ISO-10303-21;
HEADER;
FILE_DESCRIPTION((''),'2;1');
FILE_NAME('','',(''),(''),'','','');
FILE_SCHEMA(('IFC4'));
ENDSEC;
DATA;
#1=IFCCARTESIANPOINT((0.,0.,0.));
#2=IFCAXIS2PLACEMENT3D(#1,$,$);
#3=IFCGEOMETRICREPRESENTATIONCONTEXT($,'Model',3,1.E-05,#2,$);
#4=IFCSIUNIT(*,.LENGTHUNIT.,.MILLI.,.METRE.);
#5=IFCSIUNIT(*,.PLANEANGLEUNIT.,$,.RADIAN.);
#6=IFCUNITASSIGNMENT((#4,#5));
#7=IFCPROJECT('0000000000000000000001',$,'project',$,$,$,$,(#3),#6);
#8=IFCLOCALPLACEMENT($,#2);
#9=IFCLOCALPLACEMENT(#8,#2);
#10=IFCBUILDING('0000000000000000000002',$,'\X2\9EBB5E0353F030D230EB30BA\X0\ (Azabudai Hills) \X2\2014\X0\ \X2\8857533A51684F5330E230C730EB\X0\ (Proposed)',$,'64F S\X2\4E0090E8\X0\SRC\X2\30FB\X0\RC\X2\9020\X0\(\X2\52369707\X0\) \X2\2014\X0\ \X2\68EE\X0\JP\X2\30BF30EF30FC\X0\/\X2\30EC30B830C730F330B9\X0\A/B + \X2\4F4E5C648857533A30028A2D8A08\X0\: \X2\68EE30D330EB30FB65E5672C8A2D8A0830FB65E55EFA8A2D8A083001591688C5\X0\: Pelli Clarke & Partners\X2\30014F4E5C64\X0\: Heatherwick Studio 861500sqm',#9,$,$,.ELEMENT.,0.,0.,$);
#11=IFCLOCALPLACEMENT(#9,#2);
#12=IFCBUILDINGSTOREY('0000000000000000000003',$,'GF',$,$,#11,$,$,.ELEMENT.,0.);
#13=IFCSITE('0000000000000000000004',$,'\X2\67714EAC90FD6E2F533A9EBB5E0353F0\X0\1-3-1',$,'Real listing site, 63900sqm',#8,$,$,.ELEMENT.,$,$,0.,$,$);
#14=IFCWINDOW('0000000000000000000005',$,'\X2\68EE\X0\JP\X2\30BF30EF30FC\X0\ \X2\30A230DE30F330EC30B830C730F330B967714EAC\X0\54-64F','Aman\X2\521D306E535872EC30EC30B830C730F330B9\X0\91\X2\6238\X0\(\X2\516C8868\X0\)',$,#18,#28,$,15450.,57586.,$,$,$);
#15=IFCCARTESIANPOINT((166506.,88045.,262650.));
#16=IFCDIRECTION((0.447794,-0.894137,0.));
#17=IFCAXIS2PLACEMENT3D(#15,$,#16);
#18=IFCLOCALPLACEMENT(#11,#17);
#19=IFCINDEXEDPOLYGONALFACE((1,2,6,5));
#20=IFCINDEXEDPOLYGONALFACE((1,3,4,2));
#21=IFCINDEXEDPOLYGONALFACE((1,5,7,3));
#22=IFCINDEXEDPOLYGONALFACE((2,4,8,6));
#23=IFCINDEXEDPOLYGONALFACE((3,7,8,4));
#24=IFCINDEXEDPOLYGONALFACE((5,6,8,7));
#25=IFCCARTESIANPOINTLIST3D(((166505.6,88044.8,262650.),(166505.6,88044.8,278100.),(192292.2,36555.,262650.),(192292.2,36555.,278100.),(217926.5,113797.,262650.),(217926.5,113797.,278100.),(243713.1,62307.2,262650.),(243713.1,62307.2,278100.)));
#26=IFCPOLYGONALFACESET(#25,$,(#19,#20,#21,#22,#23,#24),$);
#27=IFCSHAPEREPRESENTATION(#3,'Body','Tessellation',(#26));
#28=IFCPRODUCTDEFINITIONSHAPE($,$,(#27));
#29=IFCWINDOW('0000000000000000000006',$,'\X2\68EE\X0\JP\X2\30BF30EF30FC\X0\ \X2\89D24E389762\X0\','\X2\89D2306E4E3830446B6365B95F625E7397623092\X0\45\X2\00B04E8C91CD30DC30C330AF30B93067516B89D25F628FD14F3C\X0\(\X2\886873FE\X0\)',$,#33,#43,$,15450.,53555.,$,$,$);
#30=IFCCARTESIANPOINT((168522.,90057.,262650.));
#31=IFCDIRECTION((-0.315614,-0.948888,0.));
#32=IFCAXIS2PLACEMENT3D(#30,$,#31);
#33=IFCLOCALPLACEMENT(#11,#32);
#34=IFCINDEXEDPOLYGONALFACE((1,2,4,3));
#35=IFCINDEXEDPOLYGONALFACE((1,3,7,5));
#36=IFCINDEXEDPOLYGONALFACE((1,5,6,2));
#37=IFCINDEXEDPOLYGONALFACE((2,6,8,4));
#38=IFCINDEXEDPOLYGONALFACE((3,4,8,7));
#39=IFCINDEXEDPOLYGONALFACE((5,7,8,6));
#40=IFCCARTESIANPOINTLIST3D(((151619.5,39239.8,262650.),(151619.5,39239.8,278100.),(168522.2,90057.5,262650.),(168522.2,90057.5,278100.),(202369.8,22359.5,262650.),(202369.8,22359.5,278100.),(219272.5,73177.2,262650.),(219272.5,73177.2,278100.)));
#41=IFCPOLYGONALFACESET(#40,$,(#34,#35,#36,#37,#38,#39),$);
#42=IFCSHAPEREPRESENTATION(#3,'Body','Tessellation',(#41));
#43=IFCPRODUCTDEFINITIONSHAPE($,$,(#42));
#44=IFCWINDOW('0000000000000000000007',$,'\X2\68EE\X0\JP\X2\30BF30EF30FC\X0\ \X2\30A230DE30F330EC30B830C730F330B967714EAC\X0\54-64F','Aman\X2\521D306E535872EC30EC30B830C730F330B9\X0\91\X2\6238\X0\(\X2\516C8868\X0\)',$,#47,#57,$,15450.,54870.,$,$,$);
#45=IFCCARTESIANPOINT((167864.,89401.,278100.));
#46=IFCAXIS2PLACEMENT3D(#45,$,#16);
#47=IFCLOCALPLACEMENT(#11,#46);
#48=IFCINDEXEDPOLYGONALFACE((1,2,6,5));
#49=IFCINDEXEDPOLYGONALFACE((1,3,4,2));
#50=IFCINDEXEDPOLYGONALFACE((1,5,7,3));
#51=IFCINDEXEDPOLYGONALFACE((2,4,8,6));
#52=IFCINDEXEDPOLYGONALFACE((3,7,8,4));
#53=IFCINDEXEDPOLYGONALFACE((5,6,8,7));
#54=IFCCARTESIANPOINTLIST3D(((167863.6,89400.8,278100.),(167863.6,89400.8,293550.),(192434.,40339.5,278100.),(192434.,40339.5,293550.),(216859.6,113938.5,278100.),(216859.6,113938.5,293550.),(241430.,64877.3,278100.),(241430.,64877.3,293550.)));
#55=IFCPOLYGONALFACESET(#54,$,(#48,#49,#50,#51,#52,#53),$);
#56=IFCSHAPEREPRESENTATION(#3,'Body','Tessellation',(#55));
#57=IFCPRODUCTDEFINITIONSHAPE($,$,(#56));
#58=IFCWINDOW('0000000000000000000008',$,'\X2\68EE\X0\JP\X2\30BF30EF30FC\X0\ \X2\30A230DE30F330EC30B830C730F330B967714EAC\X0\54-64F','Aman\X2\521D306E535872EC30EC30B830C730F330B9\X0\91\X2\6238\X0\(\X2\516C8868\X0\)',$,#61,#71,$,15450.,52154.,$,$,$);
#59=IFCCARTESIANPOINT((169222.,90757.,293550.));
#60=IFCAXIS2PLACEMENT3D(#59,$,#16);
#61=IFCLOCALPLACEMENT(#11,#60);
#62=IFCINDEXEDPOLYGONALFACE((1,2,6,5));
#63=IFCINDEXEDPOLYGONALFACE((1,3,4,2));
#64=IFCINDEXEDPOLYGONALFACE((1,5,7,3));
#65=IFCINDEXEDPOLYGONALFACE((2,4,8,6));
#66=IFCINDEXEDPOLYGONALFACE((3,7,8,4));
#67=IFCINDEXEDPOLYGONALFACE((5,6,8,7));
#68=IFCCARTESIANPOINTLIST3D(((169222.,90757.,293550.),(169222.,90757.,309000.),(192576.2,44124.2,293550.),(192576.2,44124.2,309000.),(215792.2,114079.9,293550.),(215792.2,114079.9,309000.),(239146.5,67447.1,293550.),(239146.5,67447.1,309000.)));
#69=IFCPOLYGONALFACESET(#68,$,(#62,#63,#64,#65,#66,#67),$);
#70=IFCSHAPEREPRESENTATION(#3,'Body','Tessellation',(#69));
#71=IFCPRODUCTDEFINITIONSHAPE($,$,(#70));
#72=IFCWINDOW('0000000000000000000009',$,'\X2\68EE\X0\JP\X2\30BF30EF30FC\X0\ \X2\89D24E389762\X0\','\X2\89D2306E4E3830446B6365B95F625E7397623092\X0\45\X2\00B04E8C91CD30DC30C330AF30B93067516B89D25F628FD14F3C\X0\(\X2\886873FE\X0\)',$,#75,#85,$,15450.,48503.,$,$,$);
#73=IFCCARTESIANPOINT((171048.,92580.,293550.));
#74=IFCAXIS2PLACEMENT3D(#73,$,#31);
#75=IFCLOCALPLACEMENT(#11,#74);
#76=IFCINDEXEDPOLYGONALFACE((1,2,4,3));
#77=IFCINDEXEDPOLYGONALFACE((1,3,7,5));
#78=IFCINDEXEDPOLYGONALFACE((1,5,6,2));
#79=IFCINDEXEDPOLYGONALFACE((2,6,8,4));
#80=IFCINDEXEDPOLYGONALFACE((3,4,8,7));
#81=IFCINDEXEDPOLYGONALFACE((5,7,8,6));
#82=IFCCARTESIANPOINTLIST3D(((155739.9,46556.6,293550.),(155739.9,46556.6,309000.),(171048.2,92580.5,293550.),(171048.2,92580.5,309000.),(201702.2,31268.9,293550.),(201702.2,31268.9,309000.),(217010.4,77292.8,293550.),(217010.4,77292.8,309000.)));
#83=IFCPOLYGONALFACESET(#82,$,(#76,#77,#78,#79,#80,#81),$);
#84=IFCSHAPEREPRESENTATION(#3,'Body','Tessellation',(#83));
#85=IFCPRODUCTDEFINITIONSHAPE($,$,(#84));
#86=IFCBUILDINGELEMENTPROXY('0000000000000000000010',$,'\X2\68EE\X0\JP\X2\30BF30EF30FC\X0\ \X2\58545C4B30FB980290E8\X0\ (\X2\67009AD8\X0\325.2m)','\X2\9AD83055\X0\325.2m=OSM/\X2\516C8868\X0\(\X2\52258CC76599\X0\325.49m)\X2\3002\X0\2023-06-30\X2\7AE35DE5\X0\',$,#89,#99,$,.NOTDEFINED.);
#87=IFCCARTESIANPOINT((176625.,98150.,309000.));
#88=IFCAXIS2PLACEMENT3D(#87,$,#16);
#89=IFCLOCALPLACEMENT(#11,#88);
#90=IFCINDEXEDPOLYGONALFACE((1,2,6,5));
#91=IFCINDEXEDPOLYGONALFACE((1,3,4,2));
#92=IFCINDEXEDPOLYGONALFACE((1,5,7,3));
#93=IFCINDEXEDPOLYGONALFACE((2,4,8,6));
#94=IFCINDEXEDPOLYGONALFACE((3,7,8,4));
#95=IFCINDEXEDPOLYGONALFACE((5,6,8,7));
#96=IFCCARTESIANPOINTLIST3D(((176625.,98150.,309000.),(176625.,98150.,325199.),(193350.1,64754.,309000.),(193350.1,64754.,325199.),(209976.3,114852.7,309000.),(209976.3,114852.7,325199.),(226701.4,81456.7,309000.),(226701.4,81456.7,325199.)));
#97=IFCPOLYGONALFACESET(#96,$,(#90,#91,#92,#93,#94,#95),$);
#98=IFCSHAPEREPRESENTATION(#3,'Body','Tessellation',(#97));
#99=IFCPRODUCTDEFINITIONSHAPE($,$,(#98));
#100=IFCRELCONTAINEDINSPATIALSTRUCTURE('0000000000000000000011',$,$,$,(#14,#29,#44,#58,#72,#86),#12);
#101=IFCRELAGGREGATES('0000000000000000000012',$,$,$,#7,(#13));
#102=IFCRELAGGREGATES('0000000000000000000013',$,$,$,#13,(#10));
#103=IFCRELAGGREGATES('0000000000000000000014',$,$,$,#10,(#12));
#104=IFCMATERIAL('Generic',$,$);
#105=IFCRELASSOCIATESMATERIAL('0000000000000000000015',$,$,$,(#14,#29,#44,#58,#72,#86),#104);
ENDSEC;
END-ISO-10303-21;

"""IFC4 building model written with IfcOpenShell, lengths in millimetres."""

from ifc_helpers import new_model, si_unit, frame, frame_2d, origin, place, context, project, spatial, rectangle, extrude, material, element, save


model = new_model("IFC4")

# Units and contexts
model_context = context("Model", 3, precision=1e-05, world=origin())
ifc_project = project(units=[si_unit("LENGTHUNIT", "METRE", prefix="MILLI"), si_unit("PLANEANGLEUNIT", "RADIAN")], contexts=[model_context])

# Site, building, storey
site_placement = place(None, origin())
site = spatial("IfcSite", under=ifc_project, at=site_placement, Name="東京都港区麻布台1-3-1", ObjectType="Real listing site, 63900sqm", CompositionType="ELEMENT", RefElevation=0.0)
building_placement = place(site_placement, origin())
building = spatial("IfcBuilding", under=site, at=building_placement, Name="麻布台ヒルズ (Azabudai Hills) — 街区全体モデル (Proposed)", ObjectType="64F S一部SRC・RC造(制震) — 森JPタワー/レジデンスA/B + 低層街区。設計: 森ビル・日本設計・日建設計、外装: Pelli Clarke & Partners、低層: Heatherwick Studio 861500sqm", CompositionType="ELEMENT", ElevationOfRefHeight=0.0, ElevationOfTerrain=0.0)
storey_placement = place(building_placement, origin())
storey = spatial("IfcBuildingStorey", under=building, at=storey_placement, Name="GF", CompositionType="ELEMENT", Elevation=0.0)

# Windows
ifc_material = material(Name="Generic")
window_1_placement = place(storey_placement, frame((166506.0, 88045.0, 262650.0), x_axis=(0.447794, -0.894137, 0.0)))
element("IfcWindow", 1, at=window_1_placement, inside=storey, material=ifc_material, Name="森JPタワー アマンレジデンス東京54-64F", Description="Aman初の単独レジデンス91戸(公表)", OverallHeight=15450.0, OverallWidth=57586.0, context=model_context, shape_type="SweptSolid", body=[
    extrude(rectangle(XDim=57586.0, YDim=57509.0, at=frame_2d((28793.0, 28754.0))), frame((166506.0, 88045.0, 262650.0), x_axis=(0.447794, -0.894137, 0.0)), (0.0, 0.0, 1.0), 15450.0),
])
window_2_placement = place(storey_placement, frame((168522.0, 90057.0, 262650.0), x_axis=(-0.315614, -0.948888, 0.0)))
element("IfcWindow", 2, at=window_2_placement, inside=storey, material=ifc_material, Name="森JPタワー 角丸面", Description="角の丸い正方形平面を45°二重ボックスで八角形近似(表現)", OverallHeight=15450.0, OverallWidth=53555.0, context=model_context, shape_type="SweptSolid", body=[
    extrude(rectangle(XDim=53555.0, YDim=53484.0, at=frame_2d((26777.0, 26742.0))), frame((168522.0, 90057.0, 262650.0), x_axis=(-0.315614, -0.948888, 0.0)), (0.0, 0.0, 1.0), 15450.0),
])
window_3_placement = place(storey_placement, frame((167864.0, 89401.0, 278100.0), x_axis=(0.447794, -0.894137, 0.0)))
element("IfcWindow", 3, at=window_3_placement, inside=storey, material=ifc_material, Name="森JPタワー アマンレジデンス東京54-64F", Description="Aman初の単独レジデンス91戸(公表)", OverallHeight=15450.0, OverallWidth=54870.0, context=model_context, shape_type="SweptSolid", body=[
    extrude(rectangle(XDim=54870.0, YDim=54797.0, at=frame_2d((27435.0, 27398.0))), frame((167864.0, 89401.0, 278100.0), x_axis=(0.447794, -0.894137, 0.0)), (0.0, 0.0, 1.0), 15450.0),
])
window_4_placement = place(storey_placement, frame((169222.0, 90757.0, 293550.0), x_axis=(0.447794, -0.894137, 0.0)))
element("IfcWindow", 4, at=window_4_placement, inside=storey, material=ifc_material, Name="森JPタワー アマンレジデンス東京54-64F", Description="Aman初の単独レジデンス91戸(公表)", OverallHeight=15450.0, OverallWidth=52154.0, context=model_context, shape_type="SweptSolid", body=[
    extrude(rectangle(XDim=52154.0, YDim=52084.0, at=frame_2d((26077.0, 26042.0))), frame((169222.0, 90757.0, 293550.0), x_axis=(0.447794, -0.894137, 0.0)), (0.0, 0.0, 1.0), 15450.0),
])
window_5_placement = place(storey_placement, frame((171048.0, 92580.0, 293550.0), x_axis=(-0.315614, -0.948888, 0.0)))
element("IfcWindow", 5, at=window_5_placement, inside=storey, material=ifc_material, Name="森JPタワー 角丸面", Description="角の丸い正方形平面を45°二重ボックスで八角形近似(表現)", OverallHeight=15450.0, OverallWidth=48503.0, context=model_context, shape_type="SweptSolid", body=[
    extrude(rectangle(XDim=48503.0, YDim=48438.0, at=frame_2d((24251.0, 24219.0))), frame((171048.0, 92580.0, 293550.0), x_axis=(-0.315614, -0.948888, 0.0)), (0.0, 0.0, 1.0), 15450.0),
])

# Building element proxy
proxy_placement = place(storey_placement, frame((176625.0, 98150.0, 309000.0), x_axis=(0.447794, -0.894137, 0.0)))
element("IfcBuildingElementProxy", 6, at=proxy_placement, inside=storey, material=ifc_material, Name="森JPタワー 塔屋・頂部 (最高325.2m)", Description="高さ325.2m=OSM/公表(別資料325.49m)。2023-06-30竣工", PredefinedType="NOTDEFINED", context=model_context, shape_type="SweptSolid", body=[
    extrude(rectangle(XDim=37350.0, YDim=37300.0, at=frame_2d((18675.0, 18650.0))), frame((176625.0, 98150.0, 309000.0), x_axis=(0.447794, -0.894137, 0.0)), (0.0, 0.0, 1.0), 16199.0),
])

save(model, "model.ifc")
